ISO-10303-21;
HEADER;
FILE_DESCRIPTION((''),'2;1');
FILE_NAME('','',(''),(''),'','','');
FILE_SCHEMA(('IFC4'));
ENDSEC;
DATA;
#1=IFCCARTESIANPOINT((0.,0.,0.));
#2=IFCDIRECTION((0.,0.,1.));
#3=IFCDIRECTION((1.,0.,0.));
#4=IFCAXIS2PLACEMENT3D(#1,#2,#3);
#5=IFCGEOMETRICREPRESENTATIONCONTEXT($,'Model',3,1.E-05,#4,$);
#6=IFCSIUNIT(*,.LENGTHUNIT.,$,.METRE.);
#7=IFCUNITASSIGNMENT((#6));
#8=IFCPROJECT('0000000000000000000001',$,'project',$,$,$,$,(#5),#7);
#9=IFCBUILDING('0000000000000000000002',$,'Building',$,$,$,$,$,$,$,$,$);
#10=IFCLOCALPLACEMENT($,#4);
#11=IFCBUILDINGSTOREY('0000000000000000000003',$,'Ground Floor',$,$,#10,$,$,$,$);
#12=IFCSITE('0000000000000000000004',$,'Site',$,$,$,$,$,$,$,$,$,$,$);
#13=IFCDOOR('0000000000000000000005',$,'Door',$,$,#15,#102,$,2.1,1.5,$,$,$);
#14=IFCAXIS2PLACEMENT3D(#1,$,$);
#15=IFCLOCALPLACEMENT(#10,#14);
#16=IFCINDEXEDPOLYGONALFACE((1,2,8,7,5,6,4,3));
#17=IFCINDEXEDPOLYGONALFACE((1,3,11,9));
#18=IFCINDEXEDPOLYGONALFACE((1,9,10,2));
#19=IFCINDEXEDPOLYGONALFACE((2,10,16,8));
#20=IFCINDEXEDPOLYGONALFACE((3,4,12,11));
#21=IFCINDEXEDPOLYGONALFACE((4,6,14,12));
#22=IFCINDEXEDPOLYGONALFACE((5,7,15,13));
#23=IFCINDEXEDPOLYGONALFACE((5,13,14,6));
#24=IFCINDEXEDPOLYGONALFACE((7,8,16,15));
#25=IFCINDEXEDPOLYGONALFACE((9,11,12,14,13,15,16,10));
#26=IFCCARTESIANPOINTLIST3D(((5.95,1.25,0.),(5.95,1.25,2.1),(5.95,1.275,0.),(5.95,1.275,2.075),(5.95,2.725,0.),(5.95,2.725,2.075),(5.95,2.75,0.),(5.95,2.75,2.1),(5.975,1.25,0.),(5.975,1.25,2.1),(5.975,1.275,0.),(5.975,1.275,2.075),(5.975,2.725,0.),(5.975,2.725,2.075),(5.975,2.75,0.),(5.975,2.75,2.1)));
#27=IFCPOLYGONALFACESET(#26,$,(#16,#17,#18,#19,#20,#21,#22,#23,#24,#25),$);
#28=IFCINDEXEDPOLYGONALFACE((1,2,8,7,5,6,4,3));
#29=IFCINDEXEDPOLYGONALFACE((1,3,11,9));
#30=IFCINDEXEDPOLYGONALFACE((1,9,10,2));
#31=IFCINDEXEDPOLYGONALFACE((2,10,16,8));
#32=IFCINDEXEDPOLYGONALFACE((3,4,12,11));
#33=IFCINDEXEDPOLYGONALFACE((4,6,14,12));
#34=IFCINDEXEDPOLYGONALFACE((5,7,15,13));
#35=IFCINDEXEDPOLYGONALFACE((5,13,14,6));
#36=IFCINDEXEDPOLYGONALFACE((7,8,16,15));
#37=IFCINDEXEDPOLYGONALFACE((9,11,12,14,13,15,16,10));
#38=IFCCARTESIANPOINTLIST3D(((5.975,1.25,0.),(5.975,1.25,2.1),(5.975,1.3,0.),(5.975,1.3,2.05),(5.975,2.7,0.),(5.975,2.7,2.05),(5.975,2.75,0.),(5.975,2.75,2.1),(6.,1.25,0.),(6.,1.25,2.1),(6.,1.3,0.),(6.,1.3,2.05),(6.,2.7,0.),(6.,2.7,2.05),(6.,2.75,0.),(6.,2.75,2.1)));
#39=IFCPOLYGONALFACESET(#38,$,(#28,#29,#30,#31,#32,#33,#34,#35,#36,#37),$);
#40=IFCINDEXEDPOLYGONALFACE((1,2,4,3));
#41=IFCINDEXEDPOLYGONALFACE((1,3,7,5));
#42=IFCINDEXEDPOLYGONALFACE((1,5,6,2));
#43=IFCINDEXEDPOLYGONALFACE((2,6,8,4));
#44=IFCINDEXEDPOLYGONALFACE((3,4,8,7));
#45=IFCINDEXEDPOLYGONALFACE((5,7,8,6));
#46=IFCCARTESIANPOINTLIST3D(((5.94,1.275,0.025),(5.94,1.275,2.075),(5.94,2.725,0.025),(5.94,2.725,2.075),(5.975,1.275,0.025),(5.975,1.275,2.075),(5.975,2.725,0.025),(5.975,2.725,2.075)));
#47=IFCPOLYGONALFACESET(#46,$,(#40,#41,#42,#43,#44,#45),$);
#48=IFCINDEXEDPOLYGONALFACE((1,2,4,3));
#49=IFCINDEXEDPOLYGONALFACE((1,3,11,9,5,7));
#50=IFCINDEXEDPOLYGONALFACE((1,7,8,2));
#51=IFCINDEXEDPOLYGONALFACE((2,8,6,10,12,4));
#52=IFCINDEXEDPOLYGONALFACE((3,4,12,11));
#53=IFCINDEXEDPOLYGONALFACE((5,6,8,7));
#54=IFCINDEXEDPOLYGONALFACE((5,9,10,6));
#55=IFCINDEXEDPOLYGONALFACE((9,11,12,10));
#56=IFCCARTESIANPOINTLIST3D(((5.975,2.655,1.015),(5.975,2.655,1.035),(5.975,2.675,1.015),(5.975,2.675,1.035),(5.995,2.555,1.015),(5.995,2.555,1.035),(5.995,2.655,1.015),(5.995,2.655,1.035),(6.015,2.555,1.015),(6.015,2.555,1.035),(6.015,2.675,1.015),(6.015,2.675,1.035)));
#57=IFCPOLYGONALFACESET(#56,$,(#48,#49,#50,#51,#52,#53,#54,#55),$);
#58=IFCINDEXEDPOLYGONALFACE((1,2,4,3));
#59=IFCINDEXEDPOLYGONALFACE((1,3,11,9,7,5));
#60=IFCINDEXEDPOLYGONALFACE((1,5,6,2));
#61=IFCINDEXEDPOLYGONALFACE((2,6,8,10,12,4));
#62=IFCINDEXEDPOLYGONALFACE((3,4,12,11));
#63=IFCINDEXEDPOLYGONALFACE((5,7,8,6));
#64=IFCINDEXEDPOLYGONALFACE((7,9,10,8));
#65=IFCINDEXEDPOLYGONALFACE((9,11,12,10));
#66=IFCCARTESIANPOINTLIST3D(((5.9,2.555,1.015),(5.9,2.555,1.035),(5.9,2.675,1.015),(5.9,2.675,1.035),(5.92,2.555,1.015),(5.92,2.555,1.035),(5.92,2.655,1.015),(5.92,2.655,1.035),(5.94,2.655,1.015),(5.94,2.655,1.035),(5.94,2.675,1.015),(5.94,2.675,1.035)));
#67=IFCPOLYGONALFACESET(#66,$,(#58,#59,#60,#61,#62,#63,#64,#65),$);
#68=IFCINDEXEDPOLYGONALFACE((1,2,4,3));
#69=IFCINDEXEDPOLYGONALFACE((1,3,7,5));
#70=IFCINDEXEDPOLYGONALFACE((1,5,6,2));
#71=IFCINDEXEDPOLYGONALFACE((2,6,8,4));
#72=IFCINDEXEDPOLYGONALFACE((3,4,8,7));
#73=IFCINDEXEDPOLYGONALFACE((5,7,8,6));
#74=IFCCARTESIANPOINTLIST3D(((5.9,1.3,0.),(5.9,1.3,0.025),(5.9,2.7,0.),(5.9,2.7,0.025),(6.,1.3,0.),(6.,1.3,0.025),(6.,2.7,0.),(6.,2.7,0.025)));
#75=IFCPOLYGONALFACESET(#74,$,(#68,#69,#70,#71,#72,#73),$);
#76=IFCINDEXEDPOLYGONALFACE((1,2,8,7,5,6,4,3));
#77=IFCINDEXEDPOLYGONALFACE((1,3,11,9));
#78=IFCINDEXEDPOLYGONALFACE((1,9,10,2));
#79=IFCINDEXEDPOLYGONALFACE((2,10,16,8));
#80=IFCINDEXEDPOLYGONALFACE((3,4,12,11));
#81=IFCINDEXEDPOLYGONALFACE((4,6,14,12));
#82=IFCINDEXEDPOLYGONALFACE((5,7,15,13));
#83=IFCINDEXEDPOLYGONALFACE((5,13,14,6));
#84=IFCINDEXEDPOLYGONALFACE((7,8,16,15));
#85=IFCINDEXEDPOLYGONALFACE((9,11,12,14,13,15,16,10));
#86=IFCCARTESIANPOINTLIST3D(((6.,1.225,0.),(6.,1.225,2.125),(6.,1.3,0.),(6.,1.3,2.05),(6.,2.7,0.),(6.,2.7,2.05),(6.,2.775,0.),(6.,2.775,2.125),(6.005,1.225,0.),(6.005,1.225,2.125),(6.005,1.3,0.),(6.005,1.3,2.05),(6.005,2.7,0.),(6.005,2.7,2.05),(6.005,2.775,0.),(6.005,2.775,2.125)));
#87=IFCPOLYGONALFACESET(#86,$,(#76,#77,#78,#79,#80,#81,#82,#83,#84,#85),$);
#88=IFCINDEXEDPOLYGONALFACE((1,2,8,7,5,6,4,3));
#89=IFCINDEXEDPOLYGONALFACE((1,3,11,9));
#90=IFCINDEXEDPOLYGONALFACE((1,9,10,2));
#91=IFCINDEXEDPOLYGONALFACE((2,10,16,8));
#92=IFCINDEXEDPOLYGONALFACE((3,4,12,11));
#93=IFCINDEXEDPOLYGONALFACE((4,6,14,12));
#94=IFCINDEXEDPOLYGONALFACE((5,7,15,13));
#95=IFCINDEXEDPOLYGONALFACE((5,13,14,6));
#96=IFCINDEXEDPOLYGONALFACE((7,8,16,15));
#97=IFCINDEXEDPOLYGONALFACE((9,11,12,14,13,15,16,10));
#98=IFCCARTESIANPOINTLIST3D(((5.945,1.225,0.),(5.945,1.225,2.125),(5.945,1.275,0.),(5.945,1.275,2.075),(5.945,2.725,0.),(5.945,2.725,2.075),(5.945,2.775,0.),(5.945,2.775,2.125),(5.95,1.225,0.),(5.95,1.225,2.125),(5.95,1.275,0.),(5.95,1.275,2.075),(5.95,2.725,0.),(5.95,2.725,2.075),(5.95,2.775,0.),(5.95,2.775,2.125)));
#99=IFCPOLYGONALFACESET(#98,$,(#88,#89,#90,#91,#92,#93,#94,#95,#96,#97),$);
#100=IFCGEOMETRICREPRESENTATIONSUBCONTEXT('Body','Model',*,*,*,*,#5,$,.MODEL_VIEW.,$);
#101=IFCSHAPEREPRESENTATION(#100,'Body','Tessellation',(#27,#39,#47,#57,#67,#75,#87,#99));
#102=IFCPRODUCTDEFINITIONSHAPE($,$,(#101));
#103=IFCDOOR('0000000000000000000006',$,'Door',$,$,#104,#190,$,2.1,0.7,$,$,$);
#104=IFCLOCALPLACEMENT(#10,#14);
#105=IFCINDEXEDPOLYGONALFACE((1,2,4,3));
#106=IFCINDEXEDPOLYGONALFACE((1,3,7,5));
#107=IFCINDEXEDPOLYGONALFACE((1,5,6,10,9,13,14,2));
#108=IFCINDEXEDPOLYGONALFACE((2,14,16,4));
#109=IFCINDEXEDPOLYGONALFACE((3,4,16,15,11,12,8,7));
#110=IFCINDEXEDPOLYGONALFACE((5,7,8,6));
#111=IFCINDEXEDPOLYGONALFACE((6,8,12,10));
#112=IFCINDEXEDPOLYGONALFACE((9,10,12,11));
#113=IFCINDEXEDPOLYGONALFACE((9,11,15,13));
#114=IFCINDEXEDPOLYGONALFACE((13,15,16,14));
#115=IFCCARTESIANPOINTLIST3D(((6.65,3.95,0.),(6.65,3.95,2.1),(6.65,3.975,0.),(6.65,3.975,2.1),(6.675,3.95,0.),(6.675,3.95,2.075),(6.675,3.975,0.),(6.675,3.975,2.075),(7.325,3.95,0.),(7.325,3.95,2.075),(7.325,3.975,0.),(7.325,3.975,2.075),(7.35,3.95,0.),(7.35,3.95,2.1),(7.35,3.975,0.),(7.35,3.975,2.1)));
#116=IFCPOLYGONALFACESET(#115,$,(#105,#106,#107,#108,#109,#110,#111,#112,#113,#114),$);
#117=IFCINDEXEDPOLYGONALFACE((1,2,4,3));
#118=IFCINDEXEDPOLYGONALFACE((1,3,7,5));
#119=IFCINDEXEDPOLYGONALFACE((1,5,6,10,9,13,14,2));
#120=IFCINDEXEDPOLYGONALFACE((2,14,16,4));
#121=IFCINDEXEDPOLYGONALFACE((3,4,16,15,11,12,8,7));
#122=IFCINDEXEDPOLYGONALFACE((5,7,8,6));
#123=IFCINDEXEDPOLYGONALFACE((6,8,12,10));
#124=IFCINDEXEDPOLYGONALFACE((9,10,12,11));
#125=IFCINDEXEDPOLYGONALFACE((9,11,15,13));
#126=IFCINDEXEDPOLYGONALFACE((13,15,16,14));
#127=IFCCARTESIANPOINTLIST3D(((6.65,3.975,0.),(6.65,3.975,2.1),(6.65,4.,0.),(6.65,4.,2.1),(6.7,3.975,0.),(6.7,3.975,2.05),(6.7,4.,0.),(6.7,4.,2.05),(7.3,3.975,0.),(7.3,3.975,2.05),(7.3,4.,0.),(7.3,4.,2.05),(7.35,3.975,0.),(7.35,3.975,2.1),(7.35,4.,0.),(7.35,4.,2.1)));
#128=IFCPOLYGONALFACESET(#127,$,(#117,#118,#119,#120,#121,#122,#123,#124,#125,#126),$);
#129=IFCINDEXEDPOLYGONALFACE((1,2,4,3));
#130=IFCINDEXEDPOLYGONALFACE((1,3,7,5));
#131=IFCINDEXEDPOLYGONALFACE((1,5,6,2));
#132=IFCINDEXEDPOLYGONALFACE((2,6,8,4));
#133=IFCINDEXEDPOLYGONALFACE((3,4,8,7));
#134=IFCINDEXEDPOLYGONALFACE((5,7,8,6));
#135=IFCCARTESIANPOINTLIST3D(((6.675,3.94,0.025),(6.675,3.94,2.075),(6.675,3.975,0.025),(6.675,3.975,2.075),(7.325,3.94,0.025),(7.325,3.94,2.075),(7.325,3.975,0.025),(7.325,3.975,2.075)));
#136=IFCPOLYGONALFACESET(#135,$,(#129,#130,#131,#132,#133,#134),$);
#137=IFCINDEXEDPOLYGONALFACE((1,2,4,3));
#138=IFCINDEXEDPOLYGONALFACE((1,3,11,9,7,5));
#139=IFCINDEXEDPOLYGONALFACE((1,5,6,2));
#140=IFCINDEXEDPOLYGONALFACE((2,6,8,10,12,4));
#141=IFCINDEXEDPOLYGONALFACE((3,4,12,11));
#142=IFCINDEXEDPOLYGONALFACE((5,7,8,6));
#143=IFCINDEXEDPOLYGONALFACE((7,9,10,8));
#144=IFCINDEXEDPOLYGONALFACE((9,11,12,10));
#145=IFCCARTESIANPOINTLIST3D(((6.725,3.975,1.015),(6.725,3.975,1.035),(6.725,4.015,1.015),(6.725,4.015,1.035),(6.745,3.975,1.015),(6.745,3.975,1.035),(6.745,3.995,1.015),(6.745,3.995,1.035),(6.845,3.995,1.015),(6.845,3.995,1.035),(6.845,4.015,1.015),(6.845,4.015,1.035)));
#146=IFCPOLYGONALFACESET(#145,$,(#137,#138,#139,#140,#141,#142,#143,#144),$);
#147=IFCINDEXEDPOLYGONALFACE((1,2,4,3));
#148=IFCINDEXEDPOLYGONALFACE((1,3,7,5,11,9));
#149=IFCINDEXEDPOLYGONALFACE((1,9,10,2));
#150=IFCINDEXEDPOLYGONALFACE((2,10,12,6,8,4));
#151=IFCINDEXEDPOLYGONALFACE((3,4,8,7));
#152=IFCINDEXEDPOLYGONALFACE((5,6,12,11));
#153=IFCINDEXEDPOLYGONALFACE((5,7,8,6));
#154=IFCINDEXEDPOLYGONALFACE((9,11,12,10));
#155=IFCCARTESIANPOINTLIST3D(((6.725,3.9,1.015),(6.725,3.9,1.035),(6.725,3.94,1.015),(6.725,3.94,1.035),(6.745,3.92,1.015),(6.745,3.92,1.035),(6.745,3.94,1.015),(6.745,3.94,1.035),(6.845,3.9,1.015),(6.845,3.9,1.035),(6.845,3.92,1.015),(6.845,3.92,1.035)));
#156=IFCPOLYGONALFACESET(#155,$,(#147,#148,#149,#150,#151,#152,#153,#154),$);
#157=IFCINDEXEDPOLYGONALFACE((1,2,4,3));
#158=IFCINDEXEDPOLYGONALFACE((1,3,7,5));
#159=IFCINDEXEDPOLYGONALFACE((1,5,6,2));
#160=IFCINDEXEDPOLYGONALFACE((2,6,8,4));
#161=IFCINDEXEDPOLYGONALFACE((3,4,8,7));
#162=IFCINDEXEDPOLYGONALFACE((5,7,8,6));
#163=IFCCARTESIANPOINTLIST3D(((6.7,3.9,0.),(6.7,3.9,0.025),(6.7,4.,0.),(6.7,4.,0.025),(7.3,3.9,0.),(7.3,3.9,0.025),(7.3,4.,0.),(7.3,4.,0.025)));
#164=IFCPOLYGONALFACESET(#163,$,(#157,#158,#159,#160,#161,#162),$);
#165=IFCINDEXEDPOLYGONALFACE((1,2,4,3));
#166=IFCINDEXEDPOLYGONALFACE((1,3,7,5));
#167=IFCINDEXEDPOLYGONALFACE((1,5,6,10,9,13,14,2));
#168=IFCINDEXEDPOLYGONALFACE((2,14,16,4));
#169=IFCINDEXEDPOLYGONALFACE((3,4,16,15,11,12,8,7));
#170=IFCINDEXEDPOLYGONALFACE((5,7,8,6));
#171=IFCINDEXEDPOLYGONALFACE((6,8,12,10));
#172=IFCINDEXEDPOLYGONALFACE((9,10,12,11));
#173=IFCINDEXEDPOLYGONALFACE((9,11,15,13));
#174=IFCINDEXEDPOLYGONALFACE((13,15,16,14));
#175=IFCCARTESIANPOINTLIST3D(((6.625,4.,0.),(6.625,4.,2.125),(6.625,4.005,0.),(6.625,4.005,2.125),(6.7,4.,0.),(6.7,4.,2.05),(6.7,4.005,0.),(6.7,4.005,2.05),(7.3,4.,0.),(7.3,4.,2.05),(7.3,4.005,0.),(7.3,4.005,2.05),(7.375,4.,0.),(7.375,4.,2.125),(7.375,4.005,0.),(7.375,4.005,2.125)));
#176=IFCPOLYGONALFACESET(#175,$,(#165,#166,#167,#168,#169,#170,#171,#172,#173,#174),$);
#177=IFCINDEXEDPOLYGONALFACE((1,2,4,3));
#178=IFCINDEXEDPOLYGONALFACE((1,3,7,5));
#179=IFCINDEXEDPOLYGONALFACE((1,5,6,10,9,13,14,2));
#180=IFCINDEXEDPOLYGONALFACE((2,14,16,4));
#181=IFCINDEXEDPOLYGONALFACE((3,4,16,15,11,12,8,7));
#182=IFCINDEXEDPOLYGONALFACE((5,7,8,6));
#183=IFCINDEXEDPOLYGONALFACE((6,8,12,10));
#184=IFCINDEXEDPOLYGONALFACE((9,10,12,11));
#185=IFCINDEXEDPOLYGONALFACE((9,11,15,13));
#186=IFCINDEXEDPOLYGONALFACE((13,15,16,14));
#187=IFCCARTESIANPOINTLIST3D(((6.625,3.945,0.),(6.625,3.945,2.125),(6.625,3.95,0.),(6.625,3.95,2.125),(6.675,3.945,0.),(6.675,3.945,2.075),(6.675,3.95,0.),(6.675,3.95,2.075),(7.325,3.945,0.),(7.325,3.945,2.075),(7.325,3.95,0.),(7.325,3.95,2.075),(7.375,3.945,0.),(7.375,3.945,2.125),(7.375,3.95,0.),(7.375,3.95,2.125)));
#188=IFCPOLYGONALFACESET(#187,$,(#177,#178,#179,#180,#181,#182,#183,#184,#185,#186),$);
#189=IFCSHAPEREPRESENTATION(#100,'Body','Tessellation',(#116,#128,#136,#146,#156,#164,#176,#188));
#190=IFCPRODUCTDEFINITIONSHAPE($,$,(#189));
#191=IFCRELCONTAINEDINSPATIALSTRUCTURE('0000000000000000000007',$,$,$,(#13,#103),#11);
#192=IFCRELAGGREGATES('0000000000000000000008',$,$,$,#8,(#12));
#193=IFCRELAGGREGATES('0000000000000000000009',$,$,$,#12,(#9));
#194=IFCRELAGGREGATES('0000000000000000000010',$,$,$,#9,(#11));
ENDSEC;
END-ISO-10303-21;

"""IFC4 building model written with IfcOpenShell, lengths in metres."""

from ifc_helpers import new_model, si_unit, frame, origin_with_axes, place, context, subcontext, project, spatial, line, indexed_curve, outline, extrude, element, save


model = new_model("IFC4")

# Units and contexts
model_context = context("Model", 3, precision=1e-05, world=origin_with_axes())
body_context = subcontext(model_context, "Body", "Model", "MODEL_VIEW")
ifc_project = project(units=[si_unit("LENGTHUNIT", "METRE")], contexts=[model_context])

# Site, building, storey
site = spatial("IfcSite", under=ifc_project, Name="Site")
building = spatial("IfcBuilding", under=site, Name="Building")
storey_placement = place(None, origin_with_axes())
storey = spatial("IfcBuildingStorey", under=building, at=storey_placement, Name="Ground Floor")

# Doors
door_1_placement = place(storey_placement, frame((6.0, 1.25, 0.0), z_axis=(0.0, 0.0, 1.0), x_axis=(0.0, 1.0, 0.0)))
element("IfcDoor", 1, at=door_1_placement, inside=storey, Name="Door", OverallHeight=2.1, OverallWidth=1.5, context=body_context, shape_type="SweptSolid", body=[
    extrude(outline(indexed_curve([(0.0, 0.0), (0.0, 2.1), (1.5, 2.1), (1.5, 0.0), (1.475, 0.0), (1.475, 2.075), (0.025, 2.075), (0.025, 0.0)], segments=[line(1, 2, 3, 4, 5, 6, 7, 8, 1)])), frame((0.0, 0.025, 0.0), z_axis=(0.0, -1.0, 0.0), x_axis=(1.0, 0.0, 0.0)), (0.0, 0.0, -1.0), 0.025),
    extrude(outline(indexed_curve([(0.0, 0.0), (0.0, 2.1), (1.5, 2.1), (1.5, 0.0), (1.45, 0.0), (1.45, 2.05), (0.05, 2.05), (0.05, 0.0)], segments=[line(1, 2, 3, 4, 5, 6, 7, 8, 1)])), frame((0.0, 0.0, 0.0), z_axis=(0.0, -1.0, 0.0), x_axis=(1.0, 0.0, 0.0)), (0.0, 0.0, -1.0), 0.025),
    extrude(outline(indexed_curve([(0.0, 0.0), (1.45, 0.0), (1.45, 0.035), (0.0, 0.035)], segments=[line(1, 2, 3, 4, 1)])), frame((0.025, 0.025, 0.025), z_axis=(0.0, 0.0, 1.0), x_axis=(1.0, 0.0, 0.0)), (0.0, 0.0, 1.0), 2.05),
    extrude(outline(indexed_curve([(0.0, 0.0), (0.0, -0.04), (-0.12, -0.04), (-0.12, -0.02), (-0.02, -0.02), (-0.02, 0.0)], segments=[line(1, 2, 3, 4, 5, 6, 1)])), frame((1.425, 0.025, 1.015), z_axis=(0.0, 0.0, 1.0), x_axis=(1.0, 0.0, 0.0)), (0.0, 0.0, 1.0), 0.02),
    extrude(outline(indexed_curve([(0.0, 0.0), (0.0, 0.04), (-0.12, 0.04), (-0.12, 0.02), (-0.02, 0.02), (-0.02, 0.0)], segments=[line(1, 2, 3, 4, 5, 6, 1)])), frame((1.425, 0.06, 1.015), z_axis=(0.0, 0.0, 1.0), x_axis=(1.0, 0.0, 0.0)), (0.0, 0.0, 1.0), 0.02),
    extrude(outline(indexed_curve([(0.0, 0.0), (1.4, 0.0), (1.4, 0.1), (0.0, 0.1)], segments=[line(1, 2, 3, 4, 1)])), frame((0.05, 0.0, 0.0), z_axis=(0.0, 0.0, 1.0), x_axis=(1.0, 0.0, 0.0)), (0.0, 0.0, 1.0), 0.025),
    extrude(outline(indexed_curve([(0.0, 0.0), (0.0, 2.125), (1.55, 2.125), (1.55, 0.0), (1.475, 0.0), (1.475, 2.05), (0.075, 2.05), (0.075, 0.0)], segments=[line(1, 2, 3, 4, 5, 6, 7, 8, 1)])), frame((-0.025, -0.005, 0.0), z_axis=(0.0, -1.0, 0.0), x_axis=(1.0, 0.0, 0.0)), (0.0, 0.0, -1.0), 0.005),
    extrude(outline(indexed_curve([(0.0, 0.0), (0.0, 2.125), (1.55, 2.125), (1.55, 0.0), (1.5, 0.0), (1.5, 2.075), (0.05, 2.075), (0.05, 0.0)], segments=[line(1, 2, 3, 4, 5, 6, 7, 8, 1)])), frame((-0.025, 0.05, 0.0), z_axis=(0.0, -1.0, 0.0), x_axis=(1.0, 0.0, 0.0)), (0.0, 0.0, -1.0), 0.005),
])
door_2_placement = place(storey_placement, frame((7.35, 4.0, 0.0), z_axis=(0.0, 0.0, 1.0), x_axis=(-1.0, 0.0, 0.0)))
element("IfcDoor", 2, at=door_2_placement, inside=storey, Name="Door", OverallHeight=2.1, OverallWidth=0.7, context=body_context, shape_type="SweptSolid", body=[
    extrude(outline(indexed_curve([(0.0, 0.0), (0.0, 2.1), (0.7, 2.1), (0.7, 0.0), (0.675, 0.0), (0.675, 2.075), (0.025, 2.075), (0.025, 0.0)], segments=[line(1, 2, 3, 4, 5, 6, 7, 8, 1)])), frame((0.0, 0.025, 0.0), z_axis=(0.0, -1.0, 0.0), x_axis=(1.0, 0.0, 0.0)), (0.0, 0.0, -1.0), 0.025),
    extrude(outline(indexed_curve([(0.0, 0.0), (0.0, 2.1), (0.7, 2.1), (0.7, 0.0), (0.65, 0.0), (0.65, 2.05), (0.05, 2.05), (0.05, 0.0)], segments=[line(1, 2, 3, 4, 5, 6, 7, 8, 1)])), frame((0.0, 0.0, 0.0), z_axis=(0.0, -1.0, 0.0), x_axis=(1.0, 0.0, 0.0)), (0.0, 0.0, -1.0), 0.025),
    extrude(outline(indexed_curve([(0.0, 0.0), (0.65, 0.0), (0.65, 0.035), (0.0, 0.035)], segments=[line(1, 2, 3, 4, 1)])), frame((0.025, 0.025, 0.025), z_axis=(0.0, 0.0, 1.0), x_axis=(1.0, 0.0, 0.0)), (0.0, 0.0, 1.0), 2.05),
    extrude(outline(indexed_curve([(0.0, 0.0), (0.0, -0.04), (-0.12, -0.04), (-0.12, -0.02), (-0.02, -0.02), (-0.02, 0.0)], segments=[line(1, 2, 3, 4, 5, 6, 1)])), frame((0.625, 0.025, 1.015), z_axis=(0.0, 0.0, 1.0), x_axis=(1.0, 0.0, 0.0)), (0.0, 0.0, 1.0), 0.02),
    extrude(outline(indexed_curve([(0.0, 0.0), (0.0, 0.04), (-0.12, 0.04), (-0.12, 0.02), (-0.02, 0.02), (-0.02, 0.0)], segments=[line(1, 2, 3, 4, 5, 6, 1)])), frame((0.625, 0.06, 1.015), z_axis=(0.0, 0.0, 1.0), x_axis=(1.0, 0.0, 0.0)), (0.0, 0.0, 1.0), 0.02),
    extrude(outline(indexed_curve([(0.0, 0.0), (0.6, 0.0), (0.6, 0.1), (0.0, 0.1)], segments=[line(1, 2, 3, 4, 1)])), frame((0.05, 0.0, 0.0), z_axis=(0.0, 0.0, 1.0), x_axis=(1.0, 0.0, 0.0)), (0.0, 0.0, 1.0), 0.025),
    extrude(outline(indexed_curve([(0.0, 0.0), (0.0, 2.125), (0.75, 2.125), (0.75, 0.0), (0.675, 0.0), (0.675, 2.05), (0.075, 2.05), (0.075, 0.0)], segments=[line(1, 2, 3, 4, 5, 6, 7, 8, 1)])), frame((-0.025, -0.005, 0.0), z_axis=(0.0, -1.0, 0.0), x_axis=(1.0, 0.0, 0.0)), (0.0, 0.0, -1.0), 0.005),
    extrude(outline(indexed_curve([(0.0, 0.0), (0.0, 2.125), (0.75, 2.125), (0.75, 0.0), (0.7, 0.0), (0.7, 2.075), (0.05, 2.075), (0.05, 0.0)], segments=[line(1, 2, 3, 4, 5, 6, 7, 8, 1)])), frame((-0.025, 0.05, 0.0), z_axis=(0.0, -1.0, 0.0), x_axis=(1.0, 0.0, 0.0)), (0.0, 0.0, -1.0), 0.005),
])

save(model, "model.ifc")
